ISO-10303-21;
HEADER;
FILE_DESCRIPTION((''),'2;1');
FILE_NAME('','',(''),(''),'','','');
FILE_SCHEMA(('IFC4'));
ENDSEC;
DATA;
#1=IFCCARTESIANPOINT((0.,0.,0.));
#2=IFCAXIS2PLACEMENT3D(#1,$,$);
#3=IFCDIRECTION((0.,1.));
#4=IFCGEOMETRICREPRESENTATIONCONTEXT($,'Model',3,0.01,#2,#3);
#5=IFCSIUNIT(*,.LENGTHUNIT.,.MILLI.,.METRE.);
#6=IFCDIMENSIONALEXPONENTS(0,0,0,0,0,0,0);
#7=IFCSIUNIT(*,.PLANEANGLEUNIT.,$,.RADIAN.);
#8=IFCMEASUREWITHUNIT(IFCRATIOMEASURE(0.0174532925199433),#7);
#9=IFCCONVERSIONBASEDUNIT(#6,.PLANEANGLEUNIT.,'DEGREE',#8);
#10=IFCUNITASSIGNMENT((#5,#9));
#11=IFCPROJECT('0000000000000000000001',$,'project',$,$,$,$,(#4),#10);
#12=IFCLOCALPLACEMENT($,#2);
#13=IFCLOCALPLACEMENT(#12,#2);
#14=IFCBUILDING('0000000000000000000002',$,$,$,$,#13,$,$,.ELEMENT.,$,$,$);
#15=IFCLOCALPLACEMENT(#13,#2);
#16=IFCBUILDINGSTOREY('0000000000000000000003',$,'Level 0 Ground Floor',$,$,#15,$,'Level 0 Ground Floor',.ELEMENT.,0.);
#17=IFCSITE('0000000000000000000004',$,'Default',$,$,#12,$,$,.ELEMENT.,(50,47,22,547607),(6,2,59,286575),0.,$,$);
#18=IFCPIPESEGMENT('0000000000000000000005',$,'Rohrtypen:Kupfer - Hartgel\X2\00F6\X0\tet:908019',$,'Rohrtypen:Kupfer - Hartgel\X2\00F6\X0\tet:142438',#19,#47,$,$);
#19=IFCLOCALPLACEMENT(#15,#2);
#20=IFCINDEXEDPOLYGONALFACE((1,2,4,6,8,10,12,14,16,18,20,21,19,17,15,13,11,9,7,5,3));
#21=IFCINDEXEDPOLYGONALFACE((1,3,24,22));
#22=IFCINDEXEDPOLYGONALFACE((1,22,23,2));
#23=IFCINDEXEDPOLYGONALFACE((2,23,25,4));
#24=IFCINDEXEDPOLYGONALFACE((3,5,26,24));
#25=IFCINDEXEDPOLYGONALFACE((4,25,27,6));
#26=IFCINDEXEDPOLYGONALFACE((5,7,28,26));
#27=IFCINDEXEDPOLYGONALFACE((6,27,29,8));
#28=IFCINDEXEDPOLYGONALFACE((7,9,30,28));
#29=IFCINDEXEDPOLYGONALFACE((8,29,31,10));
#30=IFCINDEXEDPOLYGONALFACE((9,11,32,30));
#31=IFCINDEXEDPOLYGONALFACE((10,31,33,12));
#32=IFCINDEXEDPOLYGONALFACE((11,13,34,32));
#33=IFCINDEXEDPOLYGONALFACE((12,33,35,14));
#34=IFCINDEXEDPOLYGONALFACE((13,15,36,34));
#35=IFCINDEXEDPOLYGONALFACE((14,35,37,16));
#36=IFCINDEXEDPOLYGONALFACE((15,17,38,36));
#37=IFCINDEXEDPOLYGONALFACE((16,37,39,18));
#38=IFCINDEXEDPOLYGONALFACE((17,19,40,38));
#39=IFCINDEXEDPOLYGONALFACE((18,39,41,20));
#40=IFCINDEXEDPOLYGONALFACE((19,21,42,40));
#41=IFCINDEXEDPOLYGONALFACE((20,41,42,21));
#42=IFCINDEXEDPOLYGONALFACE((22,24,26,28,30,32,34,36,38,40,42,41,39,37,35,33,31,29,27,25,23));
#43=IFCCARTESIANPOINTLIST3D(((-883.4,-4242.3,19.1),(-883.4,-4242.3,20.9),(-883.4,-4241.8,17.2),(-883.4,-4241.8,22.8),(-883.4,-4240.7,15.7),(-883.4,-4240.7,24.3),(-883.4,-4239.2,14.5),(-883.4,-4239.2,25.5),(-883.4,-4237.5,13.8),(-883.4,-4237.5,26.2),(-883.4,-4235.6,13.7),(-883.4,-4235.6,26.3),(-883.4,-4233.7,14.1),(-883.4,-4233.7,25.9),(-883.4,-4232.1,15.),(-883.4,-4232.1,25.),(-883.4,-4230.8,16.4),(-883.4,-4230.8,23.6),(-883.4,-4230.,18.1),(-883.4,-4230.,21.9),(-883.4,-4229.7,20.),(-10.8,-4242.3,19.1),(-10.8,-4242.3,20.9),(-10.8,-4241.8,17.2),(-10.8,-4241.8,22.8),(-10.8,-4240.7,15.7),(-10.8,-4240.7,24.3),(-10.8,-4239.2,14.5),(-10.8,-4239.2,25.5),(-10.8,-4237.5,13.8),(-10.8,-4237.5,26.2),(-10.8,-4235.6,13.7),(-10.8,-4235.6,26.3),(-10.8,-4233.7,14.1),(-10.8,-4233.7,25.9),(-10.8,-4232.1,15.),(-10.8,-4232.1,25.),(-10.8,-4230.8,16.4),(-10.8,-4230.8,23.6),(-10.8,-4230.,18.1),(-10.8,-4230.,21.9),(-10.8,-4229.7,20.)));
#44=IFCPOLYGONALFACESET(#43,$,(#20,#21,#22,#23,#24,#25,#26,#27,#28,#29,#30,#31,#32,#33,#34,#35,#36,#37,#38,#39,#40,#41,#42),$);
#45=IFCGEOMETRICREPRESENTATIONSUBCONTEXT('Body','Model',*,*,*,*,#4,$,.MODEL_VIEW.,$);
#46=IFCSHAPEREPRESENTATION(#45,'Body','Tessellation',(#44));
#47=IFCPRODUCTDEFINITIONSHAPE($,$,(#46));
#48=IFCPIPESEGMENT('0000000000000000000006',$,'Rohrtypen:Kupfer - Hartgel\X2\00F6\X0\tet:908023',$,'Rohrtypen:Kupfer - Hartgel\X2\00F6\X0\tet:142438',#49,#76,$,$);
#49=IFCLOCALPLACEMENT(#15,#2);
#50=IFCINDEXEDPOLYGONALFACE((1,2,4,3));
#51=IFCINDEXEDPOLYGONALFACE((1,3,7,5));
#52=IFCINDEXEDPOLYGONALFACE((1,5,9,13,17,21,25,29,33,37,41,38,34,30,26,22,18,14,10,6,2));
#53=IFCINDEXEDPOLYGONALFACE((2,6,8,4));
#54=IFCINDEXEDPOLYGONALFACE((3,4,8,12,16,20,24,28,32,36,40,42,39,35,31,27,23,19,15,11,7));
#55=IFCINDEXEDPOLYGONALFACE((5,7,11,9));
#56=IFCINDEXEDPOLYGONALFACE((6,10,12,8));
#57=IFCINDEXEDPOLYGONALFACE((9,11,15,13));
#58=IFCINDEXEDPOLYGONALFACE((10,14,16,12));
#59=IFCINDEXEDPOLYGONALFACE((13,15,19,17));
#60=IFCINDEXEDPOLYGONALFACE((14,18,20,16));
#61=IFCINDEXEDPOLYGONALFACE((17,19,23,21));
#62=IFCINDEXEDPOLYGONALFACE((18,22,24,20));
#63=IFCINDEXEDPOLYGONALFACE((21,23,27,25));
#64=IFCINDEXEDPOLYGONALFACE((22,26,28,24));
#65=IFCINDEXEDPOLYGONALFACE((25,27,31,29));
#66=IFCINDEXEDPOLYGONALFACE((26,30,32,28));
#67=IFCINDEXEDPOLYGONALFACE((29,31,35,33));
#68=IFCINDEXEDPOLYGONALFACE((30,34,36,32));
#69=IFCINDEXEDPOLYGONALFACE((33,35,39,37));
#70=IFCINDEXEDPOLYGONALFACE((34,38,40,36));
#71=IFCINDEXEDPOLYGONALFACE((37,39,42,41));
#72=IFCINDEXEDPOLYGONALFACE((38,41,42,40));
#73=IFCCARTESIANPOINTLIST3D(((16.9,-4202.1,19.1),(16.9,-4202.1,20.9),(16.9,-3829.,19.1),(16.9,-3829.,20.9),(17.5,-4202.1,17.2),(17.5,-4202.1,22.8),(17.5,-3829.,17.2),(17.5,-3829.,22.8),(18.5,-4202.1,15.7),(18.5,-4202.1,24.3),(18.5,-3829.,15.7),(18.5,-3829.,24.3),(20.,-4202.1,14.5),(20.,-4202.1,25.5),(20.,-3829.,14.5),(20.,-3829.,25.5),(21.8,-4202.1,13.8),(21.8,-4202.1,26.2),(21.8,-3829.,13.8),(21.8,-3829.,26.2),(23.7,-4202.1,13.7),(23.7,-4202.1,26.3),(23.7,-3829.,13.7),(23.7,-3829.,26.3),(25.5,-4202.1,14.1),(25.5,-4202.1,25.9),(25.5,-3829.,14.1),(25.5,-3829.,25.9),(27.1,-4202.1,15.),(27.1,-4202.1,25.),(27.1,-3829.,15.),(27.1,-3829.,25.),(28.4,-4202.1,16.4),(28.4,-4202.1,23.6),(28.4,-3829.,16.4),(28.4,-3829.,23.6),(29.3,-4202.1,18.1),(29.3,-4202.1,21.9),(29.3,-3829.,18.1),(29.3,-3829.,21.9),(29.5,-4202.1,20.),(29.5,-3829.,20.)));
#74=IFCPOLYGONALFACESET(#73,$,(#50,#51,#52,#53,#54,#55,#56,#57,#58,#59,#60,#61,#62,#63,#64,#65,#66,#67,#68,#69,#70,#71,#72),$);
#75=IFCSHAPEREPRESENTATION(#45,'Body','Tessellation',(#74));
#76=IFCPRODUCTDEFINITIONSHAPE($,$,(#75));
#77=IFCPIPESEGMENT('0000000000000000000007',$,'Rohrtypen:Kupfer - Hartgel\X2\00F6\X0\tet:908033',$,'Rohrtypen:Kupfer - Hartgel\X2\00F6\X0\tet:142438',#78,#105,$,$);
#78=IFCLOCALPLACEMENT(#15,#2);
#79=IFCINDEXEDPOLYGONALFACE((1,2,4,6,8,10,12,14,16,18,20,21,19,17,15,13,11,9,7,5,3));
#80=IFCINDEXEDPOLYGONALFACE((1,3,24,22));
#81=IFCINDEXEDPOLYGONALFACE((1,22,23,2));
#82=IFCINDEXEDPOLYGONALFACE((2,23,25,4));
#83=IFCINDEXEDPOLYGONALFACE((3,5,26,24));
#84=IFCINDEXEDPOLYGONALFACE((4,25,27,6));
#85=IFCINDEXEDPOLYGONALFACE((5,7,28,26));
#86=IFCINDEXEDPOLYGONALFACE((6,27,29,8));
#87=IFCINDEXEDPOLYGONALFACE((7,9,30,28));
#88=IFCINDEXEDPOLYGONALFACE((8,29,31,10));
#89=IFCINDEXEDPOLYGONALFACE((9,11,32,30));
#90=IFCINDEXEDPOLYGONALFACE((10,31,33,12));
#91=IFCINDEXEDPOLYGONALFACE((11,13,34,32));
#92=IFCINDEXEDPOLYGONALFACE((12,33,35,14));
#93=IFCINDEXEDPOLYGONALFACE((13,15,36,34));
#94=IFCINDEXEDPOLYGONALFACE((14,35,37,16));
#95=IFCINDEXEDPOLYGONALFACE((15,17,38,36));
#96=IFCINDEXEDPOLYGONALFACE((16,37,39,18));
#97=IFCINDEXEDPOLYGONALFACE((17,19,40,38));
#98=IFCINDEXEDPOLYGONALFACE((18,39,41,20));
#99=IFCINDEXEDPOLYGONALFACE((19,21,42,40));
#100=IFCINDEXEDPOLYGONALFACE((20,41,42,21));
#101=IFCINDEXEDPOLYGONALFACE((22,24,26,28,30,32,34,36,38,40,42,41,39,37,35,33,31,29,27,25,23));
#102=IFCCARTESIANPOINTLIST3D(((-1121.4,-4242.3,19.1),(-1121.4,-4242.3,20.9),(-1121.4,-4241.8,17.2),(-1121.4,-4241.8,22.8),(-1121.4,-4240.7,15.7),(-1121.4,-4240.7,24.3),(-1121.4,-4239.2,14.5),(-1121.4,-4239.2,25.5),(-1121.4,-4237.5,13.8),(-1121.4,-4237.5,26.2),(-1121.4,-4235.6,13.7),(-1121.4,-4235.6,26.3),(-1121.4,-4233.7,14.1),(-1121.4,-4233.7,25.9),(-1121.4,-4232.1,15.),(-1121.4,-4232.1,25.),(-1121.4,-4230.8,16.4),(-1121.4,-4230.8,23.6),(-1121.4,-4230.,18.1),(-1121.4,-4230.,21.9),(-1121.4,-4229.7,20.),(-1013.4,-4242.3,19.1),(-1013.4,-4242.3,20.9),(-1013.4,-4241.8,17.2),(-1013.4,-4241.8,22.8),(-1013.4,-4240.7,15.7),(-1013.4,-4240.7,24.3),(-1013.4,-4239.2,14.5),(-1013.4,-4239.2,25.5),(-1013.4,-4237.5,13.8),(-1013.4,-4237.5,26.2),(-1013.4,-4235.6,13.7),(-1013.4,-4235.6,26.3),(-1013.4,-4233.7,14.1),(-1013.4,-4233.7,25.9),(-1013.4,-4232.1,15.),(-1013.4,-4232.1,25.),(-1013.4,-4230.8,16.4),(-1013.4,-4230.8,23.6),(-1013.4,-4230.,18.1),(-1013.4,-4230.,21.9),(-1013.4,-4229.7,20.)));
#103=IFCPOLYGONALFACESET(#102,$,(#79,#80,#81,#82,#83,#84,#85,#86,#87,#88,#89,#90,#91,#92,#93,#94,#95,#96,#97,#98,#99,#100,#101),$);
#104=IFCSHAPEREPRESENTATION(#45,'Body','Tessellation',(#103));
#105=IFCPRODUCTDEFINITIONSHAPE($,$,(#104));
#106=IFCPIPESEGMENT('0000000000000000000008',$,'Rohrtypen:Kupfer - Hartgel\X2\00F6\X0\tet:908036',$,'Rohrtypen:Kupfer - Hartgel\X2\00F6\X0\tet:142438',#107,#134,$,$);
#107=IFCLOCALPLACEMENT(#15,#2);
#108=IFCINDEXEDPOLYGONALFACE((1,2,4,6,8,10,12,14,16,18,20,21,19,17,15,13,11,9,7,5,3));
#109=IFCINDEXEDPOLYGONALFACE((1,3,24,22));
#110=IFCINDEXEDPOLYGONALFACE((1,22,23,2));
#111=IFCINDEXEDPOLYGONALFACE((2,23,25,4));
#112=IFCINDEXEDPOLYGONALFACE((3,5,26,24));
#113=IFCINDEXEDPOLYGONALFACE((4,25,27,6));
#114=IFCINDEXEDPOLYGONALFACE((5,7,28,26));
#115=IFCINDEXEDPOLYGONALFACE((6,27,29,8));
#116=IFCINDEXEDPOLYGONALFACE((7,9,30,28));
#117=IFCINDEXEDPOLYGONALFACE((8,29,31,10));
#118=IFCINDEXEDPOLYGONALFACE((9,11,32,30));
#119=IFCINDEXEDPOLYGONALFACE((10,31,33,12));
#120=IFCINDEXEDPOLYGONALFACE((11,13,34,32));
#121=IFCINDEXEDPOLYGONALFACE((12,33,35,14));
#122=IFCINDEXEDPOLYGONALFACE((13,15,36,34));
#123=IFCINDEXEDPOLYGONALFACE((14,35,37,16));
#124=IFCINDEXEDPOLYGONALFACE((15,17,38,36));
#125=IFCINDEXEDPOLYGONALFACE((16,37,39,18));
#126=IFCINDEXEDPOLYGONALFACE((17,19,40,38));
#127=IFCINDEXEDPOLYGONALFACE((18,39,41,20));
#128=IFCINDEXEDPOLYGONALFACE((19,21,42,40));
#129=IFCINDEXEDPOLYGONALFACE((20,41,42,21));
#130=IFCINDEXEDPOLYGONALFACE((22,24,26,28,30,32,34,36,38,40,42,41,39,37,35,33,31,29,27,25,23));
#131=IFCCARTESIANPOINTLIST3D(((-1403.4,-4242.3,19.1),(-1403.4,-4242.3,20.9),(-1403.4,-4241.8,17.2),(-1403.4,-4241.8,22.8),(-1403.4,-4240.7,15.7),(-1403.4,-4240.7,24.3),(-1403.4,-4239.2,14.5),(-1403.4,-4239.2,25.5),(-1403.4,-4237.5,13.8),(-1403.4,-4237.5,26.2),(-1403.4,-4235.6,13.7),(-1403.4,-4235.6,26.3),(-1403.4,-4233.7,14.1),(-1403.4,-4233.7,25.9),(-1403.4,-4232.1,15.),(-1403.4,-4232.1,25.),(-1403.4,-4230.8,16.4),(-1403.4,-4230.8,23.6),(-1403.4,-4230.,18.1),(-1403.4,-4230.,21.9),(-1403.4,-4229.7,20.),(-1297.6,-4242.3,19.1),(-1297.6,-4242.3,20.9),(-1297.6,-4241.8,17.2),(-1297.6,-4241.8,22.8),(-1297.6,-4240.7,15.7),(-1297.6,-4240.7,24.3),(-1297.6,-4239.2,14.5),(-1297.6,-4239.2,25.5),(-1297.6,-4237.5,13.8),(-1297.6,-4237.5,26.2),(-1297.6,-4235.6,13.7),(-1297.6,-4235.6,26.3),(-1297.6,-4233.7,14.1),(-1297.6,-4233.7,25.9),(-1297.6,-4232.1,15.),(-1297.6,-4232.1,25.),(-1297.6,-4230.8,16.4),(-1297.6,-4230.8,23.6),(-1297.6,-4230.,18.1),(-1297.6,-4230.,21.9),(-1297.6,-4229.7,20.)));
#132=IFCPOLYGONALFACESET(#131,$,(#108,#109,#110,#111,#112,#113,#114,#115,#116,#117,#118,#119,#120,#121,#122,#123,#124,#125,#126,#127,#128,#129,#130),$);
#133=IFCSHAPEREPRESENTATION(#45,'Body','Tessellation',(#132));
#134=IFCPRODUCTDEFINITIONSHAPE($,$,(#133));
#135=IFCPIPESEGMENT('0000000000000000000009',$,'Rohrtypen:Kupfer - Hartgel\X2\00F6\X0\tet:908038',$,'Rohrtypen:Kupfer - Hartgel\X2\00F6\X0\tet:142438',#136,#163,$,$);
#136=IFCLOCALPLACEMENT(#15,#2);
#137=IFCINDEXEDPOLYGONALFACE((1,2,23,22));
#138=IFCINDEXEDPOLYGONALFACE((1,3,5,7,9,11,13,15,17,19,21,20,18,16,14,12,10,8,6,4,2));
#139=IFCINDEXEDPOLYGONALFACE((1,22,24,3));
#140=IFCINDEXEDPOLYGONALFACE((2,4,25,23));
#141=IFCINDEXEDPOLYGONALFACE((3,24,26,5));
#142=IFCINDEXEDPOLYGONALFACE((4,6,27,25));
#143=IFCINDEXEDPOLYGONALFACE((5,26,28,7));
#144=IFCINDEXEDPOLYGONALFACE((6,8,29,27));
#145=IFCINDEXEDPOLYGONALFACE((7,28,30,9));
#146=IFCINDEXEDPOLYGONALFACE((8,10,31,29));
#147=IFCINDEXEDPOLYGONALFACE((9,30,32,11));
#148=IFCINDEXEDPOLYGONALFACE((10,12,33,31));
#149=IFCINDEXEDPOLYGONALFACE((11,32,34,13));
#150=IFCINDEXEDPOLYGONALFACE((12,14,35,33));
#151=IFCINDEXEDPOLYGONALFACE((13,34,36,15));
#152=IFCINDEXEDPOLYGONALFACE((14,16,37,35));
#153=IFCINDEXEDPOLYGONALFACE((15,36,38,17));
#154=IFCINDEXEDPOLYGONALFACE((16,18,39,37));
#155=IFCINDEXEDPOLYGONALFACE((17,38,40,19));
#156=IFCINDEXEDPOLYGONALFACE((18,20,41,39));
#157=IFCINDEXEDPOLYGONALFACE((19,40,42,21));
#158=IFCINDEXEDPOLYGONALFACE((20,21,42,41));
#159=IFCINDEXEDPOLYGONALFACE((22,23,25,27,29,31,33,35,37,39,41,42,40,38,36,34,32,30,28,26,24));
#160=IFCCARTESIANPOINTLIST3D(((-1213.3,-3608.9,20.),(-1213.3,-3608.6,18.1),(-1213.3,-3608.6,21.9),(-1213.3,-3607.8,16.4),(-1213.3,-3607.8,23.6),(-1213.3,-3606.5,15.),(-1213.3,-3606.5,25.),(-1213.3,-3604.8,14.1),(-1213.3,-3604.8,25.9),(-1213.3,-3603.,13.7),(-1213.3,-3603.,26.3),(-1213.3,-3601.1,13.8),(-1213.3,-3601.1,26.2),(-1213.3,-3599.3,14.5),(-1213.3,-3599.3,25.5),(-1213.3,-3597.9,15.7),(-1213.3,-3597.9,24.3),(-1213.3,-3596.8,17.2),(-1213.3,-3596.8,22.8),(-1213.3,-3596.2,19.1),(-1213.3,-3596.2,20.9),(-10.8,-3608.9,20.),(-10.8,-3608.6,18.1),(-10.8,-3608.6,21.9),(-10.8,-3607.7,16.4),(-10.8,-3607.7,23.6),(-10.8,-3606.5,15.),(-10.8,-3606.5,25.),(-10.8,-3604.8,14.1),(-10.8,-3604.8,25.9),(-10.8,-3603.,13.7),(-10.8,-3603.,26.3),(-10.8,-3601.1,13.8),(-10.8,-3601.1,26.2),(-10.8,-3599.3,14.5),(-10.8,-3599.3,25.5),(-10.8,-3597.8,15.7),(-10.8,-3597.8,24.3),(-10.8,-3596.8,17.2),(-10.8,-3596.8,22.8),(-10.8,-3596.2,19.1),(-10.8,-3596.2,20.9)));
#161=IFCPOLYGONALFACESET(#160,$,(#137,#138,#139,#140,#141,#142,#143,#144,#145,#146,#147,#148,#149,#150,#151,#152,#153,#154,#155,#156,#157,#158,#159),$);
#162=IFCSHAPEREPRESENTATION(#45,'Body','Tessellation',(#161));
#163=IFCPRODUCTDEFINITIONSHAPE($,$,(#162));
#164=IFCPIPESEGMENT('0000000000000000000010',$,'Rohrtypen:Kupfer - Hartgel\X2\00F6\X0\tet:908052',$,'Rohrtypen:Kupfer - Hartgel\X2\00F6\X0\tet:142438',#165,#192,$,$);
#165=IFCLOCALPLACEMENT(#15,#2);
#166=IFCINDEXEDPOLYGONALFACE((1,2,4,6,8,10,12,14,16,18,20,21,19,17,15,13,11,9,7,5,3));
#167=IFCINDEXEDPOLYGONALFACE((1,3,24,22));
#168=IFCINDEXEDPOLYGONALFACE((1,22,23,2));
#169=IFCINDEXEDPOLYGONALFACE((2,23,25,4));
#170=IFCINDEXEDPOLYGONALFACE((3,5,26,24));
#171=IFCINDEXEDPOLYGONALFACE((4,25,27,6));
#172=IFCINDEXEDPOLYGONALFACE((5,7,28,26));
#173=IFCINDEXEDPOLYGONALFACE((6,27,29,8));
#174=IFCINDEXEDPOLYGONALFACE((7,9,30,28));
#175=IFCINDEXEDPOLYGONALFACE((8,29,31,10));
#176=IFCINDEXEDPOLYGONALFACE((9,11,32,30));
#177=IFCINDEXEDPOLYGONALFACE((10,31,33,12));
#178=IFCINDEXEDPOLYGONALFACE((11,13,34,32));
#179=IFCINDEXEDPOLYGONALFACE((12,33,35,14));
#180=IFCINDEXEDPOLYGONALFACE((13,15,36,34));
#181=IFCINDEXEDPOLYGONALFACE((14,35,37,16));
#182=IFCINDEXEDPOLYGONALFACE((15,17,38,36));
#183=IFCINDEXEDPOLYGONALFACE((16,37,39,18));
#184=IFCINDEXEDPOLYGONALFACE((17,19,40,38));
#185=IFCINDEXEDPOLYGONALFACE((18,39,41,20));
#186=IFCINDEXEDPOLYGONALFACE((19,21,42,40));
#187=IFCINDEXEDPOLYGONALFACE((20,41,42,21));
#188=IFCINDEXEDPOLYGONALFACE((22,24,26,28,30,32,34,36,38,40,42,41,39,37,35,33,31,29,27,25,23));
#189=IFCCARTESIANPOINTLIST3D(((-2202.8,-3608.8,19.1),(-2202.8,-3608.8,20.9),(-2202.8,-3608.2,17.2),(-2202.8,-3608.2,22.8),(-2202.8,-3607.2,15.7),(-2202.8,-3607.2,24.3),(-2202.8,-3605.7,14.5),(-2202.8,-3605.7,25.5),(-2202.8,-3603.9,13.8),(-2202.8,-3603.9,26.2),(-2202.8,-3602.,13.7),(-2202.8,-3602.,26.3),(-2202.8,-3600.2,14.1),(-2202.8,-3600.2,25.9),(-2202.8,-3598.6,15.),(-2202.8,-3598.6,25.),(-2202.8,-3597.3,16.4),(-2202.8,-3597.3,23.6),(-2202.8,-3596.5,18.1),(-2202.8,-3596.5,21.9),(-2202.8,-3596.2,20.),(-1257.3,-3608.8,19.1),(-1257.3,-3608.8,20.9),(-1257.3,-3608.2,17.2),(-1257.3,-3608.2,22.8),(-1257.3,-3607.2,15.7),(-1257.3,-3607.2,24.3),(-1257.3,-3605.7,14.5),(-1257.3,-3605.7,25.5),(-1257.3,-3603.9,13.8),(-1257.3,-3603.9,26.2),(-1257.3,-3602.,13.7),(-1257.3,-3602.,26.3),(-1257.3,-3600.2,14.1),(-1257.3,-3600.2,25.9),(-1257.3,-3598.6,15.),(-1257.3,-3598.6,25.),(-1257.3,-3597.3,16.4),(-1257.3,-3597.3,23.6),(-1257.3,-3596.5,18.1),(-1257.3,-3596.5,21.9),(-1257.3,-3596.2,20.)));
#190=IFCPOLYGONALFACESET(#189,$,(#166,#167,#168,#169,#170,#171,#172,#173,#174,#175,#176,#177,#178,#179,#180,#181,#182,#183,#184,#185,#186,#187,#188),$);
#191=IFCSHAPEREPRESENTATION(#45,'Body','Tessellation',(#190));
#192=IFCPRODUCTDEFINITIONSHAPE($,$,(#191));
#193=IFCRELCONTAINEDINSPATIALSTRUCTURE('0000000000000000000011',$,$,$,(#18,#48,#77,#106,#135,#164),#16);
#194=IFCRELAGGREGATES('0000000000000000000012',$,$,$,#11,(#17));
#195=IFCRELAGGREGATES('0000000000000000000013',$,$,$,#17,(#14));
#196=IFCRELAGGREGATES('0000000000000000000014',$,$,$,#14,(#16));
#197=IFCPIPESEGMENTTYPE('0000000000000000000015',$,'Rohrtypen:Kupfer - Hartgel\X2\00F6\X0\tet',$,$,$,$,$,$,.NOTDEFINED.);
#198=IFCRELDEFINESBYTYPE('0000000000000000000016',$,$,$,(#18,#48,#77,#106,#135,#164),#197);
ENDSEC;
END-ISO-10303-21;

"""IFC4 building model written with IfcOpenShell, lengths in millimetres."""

from ifc_helpers import new_model, entity, si_unit, converted_unit, direction, frame, frame_2d, origin, place, context, subcontext, project, spatial, circle, extrude, type_object, element, save


model = new_model("IFC4")

# Units and contexts
model_context = context("Model", 3, precision=0.01, world=origin(), true_north=direction((0.0, 1.0)))
body_context = subcontext(model_context, "Body", "Model", "MODEL_VIEW")
ifc_project = project(units=[si_unit("LENGTHUNIT", "METRE", prefix="MILLI"), converted_unit("PLANEANGLEUNIT", "DEGREE", entity("IfcRatioMeasure", 0.0174532925199433), si_unit("PLANEANGLEUNIT", "RADIAN"), dimensions=[0, 0, 0, 0, 0, 0, 0])], contexts=[model_context])

# Site, building, storey
site_placement = place(None, origin())
site = spatial("IfcSite", under=ifc_project, at=site_placement, Name="Default", CompositionType="ELEMENT", RefLatitude=(50, 47, 22, 547607), RefLongitude=(6, 2, 59, 286575), RefElevation=0.0)
building_placement = place(site_placement, origin())
building = spatial("IfcBuilding", under=site, at=building_placement, CompositionType="ELEMENT")
storey_placement = place(building_placement, origin())
storey = spatial("IfcBuildingStorey", under=building, at=storey_placement, Name="Level 0 Ground Floor", LongName="Level 0 Ground Floor", CompositionType="ELEMENT", Elevation=0.0)

# Pipe segments
pipe_segment_type = type_object("IfcPipeSegmentType", Name="Rohrtypen:Kupfer - Hartgelötet", PredefinedType="NOTDEFINED")
pipe_segment_1_placement = place(storey_placement, frame((-883.4, -4244.0, 12.1)))
element("IfcPipeSegment", 1, at=pipe_segment_1_placement, inside=storey, type_object=pipe_segment_type, Name="Rohrtypen:Kupfer - Hartgelötet:908019", ObjectType="Rohrtypen:Kupfer - Hartgelötet:142438", context=body_context, shape_type="SweptSolid", body=[
    extrude(circle(Radius=6.3, at=frame_2d((0.0, 0.0), x_axis=(1.0, 0.0))), frame((0.0, 7.9, 7.9), z_axis=(1.0, 0.0, 0.0), x_axis=(0.0, 1.0, 0.0)), (0.0, 0.0, 1.0), 872.6),
])
pipe_segment_2_placement = place(storey_placement, frame((15.2, -4202.1, 12.1)))
element("IfcPipeSegment", 2, at=pipe_segment_2_placement, inside=storey, type_object=pipe_segment_type, Name="Rohrtypen:Kupfer - Hartgelötet:908023", ObjectType="Rohrtypen:Kupfer - Hartgelötet:142438", context=body_context, shape_type="SweptSolid", body=[
    extrude(circle(Radius=6.3, at=frame_2d((0.0, 0.0), x_axis=(1.0, 0.0))), frame((7.9, 0.0, 7.9), z_axis=(0.0, 1.0, 0.0), x_axis=(1.0, 0.0, 0.0)), (0.0, 0.0, 1.0), 373.1),
])
pipe_segment_3_placement = place(storey_placement, frame((-1121.4, -4244.0, 12.1)))
element("IfcPipeSegment", 3, at=pipe_segment_3_placement, inside=storey, type_object=pipe_segment_type, Name="Rohrtypen:Kupfer - Hartgelötet:908033", ObjectType="Rohrtypen:Kupfer - Hartgelötet:142438", context=body_context, shape_type="SweptSolid", body=[
    extrude(circle(Radius=6.3, at=frame_2d((0.0, 0.0), x_axis=(1.0, 0.0))), frame((0.0, 7.9, 7.9), z_axis=(1.0, 0.0, 0.0), x_axis=(0.0, 1.0, 0.0)), (0.0, 0.0, 1.0), 108.0),
])
pipe_segment_4_placement = place(storey_placement, frame((-1403.4, -4244.0, 12.1)))
element("IfcPipeSegment", 4, at=pipe_segment_4_placement, inside=storey, type_object=pipe_segment_type, Name="Rohrtypen:Kupfer - Hartgelötet:908036", ObjectType="Rohrtypen:Kupfer - Hartgelötet:142438", context=body_context, shape_type="SweptSolid", body=[
    extrude(circle(Radius=6.3, at=frame_2d((0.0, 0.0), x_axis=(1.0, 0.0))), frame((0.0, 7.9, 7.9), z_axis=(1.0, 0.0, 0.0), x_axis=(0.0, 1.0, 0.0)), (0.0, 0.0, 1.0), 105.8),
])
pipe_segment_5_placement = place(storey_placement, frame((-1213.3, -3610.5, 12.1)))
element("IfcPipeSegment", 5, at=pipe_segment_5_placement, inside=storey, type_object=pipe_segment_type, Name="Rohrtypen:Kupfer - Hartgelötet:908038", ObjectType="Rohrtypen:Kupfer - Hartgelötet:142438", context=body_context, shape_type="SweptSolid", body=[
    extrude(circle(Radius=6.3, at=frame_2d((0.0, 0.0), x_axis=(1.0, 0.0))), frame((0.0, 7.9, 7.9), z_axis=(1.0, 0.000017, 0.0), x_axis=(0.000017, -1.0, 0.0)), (0.0, 0.0, 1.0), 1202.5),
])
pipe_segment_6_placement = place(storey_placement, frame((-2202.8, -3610.5, 12.1)))
element("IfcPipeSegment", 6, at=pipe_segment_6_placement, inside=storey, type_object=pipe_segment_type, Name="Rohrtypen:Kupfer - Hartgelötet:908052", ObjectType="Rohrtypen:Kupfer - Hartgelötet:142438", context=body_context, shape_type="SweptSolid", body=[
    extrude(circle(Radius=6.3, at=frame_2d((0.0, 0.0), x_axis=(1.0, 0.0))), frame((0.0, 7.9, 7.9), z_axis=(1.0, 0.0, 0.0), x_axis=(0.0, 1.0, 0.0)), (0.0, 0.0, 1.0), 945.5),
])

save(model, "model.ifc")
